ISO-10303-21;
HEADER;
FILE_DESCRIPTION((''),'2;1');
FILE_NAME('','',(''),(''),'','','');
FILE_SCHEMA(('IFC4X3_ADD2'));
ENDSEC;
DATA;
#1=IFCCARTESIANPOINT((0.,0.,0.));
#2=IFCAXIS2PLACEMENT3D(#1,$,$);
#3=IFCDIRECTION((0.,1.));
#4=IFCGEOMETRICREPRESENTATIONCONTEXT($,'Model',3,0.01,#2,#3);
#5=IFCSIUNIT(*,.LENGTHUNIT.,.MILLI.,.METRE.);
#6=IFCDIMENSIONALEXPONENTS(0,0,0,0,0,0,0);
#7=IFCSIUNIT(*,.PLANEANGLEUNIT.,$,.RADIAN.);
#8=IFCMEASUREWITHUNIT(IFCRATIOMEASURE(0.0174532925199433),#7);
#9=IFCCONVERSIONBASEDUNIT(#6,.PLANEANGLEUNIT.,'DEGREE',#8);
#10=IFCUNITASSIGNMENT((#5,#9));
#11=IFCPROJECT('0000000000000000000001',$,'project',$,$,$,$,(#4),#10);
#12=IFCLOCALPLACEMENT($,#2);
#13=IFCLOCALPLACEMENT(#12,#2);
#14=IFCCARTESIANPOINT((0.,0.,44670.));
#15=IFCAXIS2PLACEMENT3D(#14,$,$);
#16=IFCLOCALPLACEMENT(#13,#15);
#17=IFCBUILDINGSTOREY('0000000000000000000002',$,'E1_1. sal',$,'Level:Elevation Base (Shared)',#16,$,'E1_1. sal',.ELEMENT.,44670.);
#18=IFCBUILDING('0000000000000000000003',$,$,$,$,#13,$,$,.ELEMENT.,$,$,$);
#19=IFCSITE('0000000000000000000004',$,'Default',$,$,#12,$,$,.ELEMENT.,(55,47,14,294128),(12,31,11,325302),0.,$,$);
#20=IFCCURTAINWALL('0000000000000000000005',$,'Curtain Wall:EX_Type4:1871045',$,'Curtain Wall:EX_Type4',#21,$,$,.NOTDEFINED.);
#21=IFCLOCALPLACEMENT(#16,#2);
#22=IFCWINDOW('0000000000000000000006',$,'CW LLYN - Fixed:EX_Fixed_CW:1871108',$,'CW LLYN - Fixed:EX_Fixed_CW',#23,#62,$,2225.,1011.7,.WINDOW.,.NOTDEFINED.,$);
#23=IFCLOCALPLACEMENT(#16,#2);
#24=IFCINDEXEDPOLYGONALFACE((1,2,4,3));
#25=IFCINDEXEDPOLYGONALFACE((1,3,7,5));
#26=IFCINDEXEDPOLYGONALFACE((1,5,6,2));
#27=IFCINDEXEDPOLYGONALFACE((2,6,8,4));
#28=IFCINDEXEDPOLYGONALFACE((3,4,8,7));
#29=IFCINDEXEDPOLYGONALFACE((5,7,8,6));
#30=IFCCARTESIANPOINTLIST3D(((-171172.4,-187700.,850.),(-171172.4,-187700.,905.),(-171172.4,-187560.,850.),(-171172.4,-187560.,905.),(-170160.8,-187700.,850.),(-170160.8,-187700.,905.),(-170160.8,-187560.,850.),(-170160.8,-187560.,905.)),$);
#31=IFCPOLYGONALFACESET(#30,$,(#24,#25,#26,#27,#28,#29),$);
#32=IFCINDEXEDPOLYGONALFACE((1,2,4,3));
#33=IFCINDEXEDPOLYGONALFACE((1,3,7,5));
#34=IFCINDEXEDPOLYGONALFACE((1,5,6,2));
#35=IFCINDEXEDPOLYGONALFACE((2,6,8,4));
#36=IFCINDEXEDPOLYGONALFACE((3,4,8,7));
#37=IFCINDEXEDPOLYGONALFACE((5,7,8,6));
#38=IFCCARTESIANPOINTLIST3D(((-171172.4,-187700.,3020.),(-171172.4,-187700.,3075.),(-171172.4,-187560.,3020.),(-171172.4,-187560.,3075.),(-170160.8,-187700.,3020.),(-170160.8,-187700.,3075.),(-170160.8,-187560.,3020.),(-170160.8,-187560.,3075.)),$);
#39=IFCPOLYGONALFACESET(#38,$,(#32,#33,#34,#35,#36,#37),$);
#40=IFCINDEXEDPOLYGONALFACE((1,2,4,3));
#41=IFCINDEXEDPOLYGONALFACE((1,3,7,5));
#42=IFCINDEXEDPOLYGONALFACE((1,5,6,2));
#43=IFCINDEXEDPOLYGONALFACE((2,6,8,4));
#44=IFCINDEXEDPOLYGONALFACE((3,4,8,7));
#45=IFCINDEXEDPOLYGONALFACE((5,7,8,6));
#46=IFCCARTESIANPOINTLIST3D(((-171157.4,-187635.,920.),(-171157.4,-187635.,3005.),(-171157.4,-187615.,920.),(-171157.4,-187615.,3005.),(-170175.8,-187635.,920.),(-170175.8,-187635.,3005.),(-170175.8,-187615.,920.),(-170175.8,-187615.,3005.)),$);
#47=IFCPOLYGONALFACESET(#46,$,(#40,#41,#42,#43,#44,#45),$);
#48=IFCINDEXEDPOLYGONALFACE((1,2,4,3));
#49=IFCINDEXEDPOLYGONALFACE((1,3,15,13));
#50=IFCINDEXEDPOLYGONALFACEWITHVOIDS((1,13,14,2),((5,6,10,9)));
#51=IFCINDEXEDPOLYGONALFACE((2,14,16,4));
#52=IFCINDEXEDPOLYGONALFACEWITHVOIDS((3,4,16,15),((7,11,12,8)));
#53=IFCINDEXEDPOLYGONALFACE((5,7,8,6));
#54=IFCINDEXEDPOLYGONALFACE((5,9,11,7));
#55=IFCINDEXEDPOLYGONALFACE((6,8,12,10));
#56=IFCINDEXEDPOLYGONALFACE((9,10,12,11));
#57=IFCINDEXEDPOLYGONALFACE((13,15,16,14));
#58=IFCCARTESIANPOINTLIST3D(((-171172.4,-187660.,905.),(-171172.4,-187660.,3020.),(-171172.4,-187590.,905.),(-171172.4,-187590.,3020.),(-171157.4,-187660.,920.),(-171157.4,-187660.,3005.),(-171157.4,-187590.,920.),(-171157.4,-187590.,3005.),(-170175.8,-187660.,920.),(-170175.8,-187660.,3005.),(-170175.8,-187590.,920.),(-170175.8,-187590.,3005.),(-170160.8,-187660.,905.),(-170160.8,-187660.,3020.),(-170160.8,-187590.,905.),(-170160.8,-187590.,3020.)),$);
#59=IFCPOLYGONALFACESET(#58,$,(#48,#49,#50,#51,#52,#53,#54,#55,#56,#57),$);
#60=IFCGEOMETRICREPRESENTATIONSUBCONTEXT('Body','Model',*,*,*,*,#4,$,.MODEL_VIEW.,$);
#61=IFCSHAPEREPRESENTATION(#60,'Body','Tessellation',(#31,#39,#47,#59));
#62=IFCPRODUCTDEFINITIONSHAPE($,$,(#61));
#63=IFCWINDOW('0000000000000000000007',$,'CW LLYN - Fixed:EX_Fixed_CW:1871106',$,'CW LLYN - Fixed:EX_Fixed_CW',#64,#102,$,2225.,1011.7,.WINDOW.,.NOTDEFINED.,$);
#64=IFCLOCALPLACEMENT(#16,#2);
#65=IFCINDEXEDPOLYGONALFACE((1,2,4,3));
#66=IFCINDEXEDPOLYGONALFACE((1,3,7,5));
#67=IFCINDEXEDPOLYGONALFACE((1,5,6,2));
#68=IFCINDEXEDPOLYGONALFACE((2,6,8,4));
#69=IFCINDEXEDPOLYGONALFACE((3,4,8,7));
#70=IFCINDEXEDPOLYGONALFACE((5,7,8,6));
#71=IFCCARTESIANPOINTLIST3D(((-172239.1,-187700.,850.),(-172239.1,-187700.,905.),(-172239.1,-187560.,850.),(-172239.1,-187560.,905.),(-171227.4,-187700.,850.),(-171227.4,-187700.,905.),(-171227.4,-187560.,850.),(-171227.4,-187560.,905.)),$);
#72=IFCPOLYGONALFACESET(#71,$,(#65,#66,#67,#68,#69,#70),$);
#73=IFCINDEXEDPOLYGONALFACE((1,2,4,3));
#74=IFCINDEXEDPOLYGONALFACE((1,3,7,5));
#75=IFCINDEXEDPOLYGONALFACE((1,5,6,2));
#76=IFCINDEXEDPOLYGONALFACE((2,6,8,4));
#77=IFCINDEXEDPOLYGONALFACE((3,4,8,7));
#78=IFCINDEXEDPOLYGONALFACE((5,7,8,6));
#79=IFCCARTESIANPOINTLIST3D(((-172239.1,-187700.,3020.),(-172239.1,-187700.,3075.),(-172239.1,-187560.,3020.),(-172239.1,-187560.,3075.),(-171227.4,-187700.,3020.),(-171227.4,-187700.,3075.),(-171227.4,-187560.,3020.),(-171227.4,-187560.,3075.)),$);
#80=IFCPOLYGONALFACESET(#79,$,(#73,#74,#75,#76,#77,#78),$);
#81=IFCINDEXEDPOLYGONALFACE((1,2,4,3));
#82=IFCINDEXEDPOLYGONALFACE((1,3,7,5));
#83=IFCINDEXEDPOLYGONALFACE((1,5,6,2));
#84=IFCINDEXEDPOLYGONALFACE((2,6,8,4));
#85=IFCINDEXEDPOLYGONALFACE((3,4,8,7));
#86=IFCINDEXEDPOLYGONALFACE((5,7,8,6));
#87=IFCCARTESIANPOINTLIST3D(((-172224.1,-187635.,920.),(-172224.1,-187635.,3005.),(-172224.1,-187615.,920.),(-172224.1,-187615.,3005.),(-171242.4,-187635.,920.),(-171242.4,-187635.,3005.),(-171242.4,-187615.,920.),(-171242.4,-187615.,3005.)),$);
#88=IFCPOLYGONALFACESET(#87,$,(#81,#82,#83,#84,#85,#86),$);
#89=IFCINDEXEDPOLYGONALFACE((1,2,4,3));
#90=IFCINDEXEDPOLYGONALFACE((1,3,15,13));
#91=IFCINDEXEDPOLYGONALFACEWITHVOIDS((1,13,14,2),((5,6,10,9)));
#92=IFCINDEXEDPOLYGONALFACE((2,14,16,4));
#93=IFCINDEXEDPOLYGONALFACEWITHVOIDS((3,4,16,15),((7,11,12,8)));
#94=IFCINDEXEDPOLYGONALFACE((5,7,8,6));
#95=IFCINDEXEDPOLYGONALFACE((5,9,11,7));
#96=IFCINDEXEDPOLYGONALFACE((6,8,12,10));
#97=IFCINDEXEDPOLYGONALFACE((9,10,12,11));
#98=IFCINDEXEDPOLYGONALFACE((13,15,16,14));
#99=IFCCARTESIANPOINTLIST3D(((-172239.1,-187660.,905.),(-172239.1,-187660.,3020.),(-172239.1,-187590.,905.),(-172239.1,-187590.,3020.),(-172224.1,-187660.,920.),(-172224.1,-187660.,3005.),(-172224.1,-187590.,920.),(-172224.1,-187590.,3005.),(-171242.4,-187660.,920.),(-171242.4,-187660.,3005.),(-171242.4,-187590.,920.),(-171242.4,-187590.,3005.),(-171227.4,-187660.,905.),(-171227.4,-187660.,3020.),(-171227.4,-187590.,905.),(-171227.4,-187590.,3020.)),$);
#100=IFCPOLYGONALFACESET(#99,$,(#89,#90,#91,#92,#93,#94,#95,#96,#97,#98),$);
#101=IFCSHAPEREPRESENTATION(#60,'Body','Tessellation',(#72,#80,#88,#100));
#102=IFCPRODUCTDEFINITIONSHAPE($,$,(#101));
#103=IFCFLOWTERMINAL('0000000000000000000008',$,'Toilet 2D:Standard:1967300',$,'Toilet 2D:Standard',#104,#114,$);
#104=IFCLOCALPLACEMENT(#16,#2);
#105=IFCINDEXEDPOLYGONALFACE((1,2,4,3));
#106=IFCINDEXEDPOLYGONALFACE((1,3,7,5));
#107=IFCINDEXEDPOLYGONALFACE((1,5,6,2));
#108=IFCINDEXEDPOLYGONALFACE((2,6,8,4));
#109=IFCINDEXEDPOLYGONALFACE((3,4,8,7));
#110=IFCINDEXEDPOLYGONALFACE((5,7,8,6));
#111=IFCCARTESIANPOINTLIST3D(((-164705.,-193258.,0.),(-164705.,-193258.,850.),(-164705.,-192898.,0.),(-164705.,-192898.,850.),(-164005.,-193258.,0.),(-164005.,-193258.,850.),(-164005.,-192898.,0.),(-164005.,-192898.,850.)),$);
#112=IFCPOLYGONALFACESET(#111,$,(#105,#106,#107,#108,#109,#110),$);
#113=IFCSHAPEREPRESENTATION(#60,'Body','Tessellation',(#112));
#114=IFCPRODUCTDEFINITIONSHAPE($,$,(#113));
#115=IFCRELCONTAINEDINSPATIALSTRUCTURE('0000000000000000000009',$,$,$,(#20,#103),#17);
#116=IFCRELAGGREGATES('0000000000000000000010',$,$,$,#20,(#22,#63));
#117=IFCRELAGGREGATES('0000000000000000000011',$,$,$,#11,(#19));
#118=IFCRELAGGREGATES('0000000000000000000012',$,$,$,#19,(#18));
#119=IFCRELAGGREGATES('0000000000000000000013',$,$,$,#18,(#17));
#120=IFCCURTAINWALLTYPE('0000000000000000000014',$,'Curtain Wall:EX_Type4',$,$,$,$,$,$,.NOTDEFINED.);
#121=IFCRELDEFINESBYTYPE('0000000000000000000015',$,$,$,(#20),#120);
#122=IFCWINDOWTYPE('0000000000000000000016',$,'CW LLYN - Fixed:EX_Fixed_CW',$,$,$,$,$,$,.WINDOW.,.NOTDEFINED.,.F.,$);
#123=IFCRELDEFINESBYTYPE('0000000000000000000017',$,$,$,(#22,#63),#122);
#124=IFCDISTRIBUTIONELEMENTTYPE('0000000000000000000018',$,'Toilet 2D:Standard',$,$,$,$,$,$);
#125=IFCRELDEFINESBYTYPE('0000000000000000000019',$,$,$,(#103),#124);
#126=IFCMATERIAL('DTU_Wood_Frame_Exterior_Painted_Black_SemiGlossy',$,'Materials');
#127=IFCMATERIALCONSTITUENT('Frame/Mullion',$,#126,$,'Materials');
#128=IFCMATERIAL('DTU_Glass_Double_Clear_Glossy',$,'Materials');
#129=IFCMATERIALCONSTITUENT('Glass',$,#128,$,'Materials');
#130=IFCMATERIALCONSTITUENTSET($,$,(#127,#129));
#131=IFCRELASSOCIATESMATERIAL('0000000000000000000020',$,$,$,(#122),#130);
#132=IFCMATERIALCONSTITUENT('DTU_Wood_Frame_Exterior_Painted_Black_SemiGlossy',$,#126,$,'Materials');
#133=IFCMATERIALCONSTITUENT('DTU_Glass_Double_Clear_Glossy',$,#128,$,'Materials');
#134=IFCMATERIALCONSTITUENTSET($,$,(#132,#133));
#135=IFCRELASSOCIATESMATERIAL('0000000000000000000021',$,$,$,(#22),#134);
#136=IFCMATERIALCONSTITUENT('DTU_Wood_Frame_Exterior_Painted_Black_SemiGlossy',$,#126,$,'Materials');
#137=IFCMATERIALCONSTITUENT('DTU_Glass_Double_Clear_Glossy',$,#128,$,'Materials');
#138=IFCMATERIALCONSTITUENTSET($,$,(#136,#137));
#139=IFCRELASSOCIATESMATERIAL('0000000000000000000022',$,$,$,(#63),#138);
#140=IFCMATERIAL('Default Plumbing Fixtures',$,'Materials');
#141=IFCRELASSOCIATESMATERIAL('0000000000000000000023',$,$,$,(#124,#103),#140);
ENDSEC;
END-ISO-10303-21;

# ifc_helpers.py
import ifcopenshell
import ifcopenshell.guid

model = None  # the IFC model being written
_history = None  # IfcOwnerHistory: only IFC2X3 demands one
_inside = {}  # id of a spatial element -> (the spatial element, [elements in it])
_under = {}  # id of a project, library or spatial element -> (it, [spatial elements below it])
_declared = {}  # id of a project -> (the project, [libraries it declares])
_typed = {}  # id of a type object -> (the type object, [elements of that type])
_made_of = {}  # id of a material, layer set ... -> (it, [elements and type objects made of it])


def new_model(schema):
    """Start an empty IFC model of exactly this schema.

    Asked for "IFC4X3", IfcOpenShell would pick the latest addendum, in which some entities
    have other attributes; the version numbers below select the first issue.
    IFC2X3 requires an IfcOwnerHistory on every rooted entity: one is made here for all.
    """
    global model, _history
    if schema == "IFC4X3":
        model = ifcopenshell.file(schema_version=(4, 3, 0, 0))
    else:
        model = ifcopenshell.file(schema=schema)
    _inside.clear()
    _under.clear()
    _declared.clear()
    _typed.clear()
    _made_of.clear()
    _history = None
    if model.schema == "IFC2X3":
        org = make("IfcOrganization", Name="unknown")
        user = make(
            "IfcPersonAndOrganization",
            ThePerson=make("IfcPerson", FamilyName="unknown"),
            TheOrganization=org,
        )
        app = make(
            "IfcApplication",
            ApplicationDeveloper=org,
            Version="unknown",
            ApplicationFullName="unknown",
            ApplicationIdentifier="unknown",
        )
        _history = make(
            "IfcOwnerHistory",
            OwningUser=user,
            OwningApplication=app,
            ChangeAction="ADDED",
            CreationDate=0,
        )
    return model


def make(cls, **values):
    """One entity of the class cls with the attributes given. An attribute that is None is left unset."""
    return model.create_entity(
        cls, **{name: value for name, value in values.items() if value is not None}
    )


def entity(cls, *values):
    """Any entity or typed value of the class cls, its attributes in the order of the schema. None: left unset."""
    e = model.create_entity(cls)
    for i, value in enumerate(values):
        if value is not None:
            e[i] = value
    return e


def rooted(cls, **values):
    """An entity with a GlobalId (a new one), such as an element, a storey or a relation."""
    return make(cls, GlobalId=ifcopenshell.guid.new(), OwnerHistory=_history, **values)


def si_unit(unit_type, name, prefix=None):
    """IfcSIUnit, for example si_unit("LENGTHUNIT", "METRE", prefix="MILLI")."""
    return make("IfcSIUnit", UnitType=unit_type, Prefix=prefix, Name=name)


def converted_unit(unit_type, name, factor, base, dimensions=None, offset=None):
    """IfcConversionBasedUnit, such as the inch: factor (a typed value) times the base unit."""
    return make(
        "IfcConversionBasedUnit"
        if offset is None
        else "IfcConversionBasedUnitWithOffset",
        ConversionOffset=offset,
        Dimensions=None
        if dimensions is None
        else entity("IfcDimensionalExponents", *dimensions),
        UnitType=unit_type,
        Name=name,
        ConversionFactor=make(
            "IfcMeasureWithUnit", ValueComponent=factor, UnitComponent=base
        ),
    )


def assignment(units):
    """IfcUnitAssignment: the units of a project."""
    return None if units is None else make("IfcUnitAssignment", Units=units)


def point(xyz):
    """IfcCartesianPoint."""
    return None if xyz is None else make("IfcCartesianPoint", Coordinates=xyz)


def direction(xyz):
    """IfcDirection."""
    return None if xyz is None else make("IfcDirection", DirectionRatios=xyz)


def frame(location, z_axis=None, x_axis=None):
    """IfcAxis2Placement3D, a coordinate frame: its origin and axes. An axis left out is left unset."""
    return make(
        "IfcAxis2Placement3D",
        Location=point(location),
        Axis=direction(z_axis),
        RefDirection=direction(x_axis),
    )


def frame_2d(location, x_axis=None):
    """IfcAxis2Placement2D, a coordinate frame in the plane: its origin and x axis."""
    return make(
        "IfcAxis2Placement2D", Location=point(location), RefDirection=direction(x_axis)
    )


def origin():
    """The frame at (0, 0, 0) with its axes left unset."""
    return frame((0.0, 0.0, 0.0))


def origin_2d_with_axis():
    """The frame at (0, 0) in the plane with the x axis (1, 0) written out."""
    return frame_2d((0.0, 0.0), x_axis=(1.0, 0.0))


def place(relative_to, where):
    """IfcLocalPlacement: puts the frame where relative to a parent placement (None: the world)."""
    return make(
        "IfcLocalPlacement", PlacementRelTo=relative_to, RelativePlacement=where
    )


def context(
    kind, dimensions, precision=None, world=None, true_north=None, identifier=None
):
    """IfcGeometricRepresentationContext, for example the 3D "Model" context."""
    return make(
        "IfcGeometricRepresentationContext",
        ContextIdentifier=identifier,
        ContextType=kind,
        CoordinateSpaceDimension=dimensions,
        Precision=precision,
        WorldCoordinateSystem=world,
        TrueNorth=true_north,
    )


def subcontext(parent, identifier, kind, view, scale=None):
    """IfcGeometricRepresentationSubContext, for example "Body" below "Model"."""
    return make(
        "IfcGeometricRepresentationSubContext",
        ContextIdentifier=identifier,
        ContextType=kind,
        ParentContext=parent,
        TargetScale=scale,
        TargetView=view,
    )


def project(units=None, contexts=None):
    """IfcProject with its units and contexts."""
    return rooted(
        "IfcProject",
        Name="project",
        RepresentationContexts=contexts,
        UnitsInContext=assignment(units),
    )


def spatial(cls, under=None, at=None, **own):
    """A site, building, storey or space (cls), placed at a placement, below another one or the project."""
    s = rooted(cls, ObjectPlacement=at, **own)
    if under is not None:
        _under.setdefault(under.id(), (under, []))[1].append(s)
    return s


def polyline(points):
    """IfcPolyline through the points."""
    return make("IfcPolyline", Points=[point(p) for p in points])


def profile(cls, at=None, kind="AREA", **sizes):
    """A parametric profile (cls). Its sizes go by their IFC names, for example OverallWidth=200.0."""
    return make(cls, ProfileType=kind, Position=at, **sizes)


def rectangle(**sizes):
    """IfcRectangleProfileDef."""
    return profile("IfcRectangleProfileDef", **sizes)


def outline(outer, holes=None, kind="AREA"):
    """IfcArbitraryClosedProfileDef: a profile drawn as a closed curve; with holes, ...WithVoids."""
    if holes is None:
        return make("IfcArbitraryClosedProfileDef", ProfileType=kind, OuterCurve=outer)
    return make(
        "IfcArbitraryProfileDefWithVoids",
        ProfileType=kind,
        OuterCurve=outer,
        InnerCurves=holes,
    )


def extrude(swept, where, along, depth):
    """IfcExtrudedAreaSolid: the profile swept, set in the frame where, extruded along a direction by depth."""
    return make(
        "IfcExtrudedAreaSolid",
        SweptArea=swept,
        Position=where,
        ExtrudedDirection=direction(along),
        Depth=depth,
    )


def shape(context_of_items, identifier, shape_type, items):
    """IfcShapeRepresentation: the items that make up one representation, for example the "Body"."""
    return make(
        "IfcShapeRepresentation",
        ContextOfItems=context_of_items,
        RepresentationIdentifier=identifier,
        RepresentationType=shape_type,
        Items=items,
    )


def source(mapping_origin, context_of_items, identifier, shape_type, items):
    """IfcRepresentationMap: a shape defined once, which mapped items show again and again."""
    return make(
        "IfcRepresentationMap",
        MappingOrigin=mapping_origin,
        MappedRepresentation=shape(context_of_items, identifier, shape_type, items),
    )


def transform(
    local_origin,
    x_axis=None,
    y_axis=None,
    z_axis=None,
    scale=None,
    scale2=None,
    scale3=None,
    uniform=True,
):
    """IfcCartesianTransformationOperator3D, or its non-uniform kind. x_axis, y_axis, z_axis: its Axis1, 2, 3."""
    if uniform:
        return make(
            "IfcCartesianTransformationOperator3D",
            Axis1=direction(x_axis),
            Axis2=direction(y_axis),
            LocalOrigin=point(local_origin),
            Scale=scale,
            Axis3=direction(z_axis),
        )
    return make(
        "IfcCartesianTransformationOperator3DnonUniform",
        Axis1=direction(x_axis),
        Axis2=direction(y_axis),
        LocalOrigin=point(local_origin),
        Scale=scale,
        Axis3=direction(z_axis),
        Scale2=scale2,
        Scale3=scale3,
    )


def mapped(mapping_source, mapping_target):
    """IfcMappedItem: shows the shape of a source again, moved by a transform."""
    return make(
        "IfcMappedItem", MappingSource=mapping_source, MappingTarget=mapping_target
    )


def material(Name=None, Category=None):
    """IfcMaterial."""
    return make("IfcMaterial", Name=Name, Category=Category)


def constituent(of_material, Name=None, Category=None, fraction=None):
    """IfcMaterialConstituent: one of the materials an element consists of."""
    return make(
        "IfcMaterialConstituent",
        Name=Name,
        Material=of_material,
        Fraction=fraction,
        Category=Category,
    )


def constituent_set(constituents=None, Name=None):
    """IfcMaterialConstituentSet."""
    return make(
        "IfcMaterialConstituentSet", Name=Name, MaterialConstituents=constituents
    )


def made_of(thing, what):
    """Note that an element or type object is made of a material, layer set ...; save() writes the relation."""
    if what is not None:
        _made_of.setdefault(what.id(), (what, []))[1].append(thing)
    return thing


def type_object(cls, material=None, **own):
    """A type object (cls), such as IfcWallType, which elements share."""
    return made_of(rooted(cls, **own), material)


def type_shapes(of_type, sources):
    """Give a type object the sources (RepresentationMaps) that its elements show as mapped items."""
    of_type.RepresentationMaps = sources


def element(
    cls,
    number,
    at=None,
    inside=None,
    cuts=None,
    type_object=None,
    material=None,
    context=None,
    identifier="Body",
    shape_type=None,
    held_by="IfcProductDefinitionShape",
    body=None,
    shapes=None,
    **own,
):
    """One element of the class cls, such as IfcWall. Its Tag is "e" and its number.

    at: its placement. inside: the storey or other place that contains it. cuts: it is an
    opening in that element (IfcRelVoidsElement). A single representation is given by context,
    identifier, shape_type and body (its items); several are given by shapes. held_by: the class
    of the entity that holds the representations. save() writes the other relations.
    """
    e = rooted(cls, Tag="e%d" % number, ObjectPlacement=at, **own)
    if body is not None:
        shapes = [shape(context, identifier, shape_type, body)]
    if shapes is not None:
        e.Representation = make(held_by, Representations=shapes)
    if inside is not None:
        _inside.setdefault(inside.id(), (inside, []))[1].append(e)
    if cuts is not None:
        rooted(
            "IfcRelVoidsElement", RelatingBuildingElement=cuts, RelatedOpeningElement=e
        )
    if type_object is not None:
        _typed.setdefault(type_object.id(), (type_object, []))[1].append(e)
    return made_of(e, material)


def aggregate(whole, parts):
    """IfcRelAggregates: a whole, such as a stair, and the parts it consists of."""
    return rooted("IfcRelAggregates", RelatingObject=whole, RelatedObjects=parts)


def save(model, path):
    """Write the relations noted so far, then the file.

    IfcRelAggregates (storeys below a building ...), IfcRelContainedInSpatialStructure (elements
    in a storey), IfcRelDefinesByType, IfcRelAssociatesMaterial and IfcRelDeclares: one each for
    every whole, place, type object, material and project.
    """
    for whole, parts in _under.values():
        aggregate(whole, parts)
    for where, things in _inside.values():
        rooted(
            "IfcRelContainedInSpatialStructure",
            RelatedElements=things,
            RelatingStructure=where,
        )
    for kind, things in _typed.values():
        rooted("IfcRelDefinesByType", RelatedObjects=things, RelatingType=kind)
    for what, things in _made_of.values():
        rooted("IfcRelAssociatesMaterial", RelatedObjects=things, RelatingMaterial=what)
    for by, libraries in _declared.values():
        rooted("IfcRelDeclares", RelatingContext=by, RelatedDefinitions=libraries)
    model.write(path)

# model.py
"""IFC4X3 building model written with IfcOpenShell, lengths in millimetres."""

from ifc_helpers import new_model, entity, si_unit, converted_unit, direction, frame, frame_2d, origin, origin_2d_with_axis, place, context, subcontext, project, spatial, polyline, rectangle, outline, extrude, source, transform, mapped, material, constituent, constituent_set, type_object, type_shapes, element, aggregate, save


model = new_model("IFC4X3")

# Units and contexts
model_context = context("Model", 3, precision=0.01, world=origin(), true_north=direction((0.0, 1.0)))
body_context = subcontext(model_context, "Body", "Model", "MODEL_VIEW")
ifc_project = project(units=[si_unit("LENGTHUNIT", "METRE", prefix="MILLI"), converted_unit("PLANEANGLEUNIT", "DEGREE", entity("IfcRatioMeasure", 0.0174532925199433), si_unit("PLANEANGLEUNIT", "RADIAN"), dimensions=[0, 0, 0, 0, 0, 0, 0])], contexts=[model_context])

# Site, building, storey
site_placement = place(None, origin())
site = spatial("IfcSite", under=ifc_project, at=site_placement, Name="Default", CompositionType="ELEMENT", RefLatitude=(55, 47, 14, 294128), RefLongitude=(12, 31, 11, 325302), RefElevation=0.0)
building_placement = place(site_placement, origin())
building = spatial("IfcBuilding", under=site, at=building_placement, CompositionType="ELEMENT")
storey_placement = place(building_placement, frame((0.0, 0.0, 44670.0)))
storey = spatial("IfcBuildingStorey", under=building, at=storey_placement, Name="E1_1. sal", ObjectType="Level:Elevation Base (Shared)", LongName="E1_1. sal", CompositionType="ELEMENT", Elevation=44670.0)

# Curtain wall
curtain_wall_type = type_object("IfcCurtainWallType", Name="Curtain Wall:EX_Type4", PredefinedType="NOTDEFINED")
curtain_wall_placement = place(storey_placement, frame((0.0, 0.0, -44670.0)))
curtain_wall = element("IfcCurtainWall", 1, at=curtain_wall_placement, inside=storey, type_object=curtain_wall_type, Name="Curtain Wall:EX_Type4:1871045", ObjectType="Curtain Wall:EX_Type4", PredefinedType="NOTDEFINED")

# Windows
ifc_material_1 = material(Name="DTU_Wood_Frame_Exterior_Painted_Black_SemiGlossy", Category="Materials")
ifc_material_2 = material(Name="DTU_Glass_Double_Clear_Glossy", Category="Materials")
ifc_constituent_1 = constituent(ifc_material_1, Name="Frame/Mullion", Category="Materials")
ifc_constituent_2 = constituent(ifc_material_2, Name="Glass", Category="Materials")
ifc_constituent_set_1 = constituent_set(constituents=[ifc_constituent_1, ifc_constituent_2])
window_type_1 = type_object("IfcWindowType", Name="CW LLYN - Fixed:EX_Fixed_CW", ParameterTakesPrecedence=False, PartitioningType="NOTDEFINED", PredefinedType="WINDOW", material=ifc_constituent_set_1)
shared_shape_1 = source(origin(), body_context, "Body", "SweptSolid", [
    extrude(rectangle(XDim=140.0, YDim=1011.7, at=origin_2d_with_axis()), frame((0.0, -130.0, 0.0), z_axis=(0.0, 0.0, 1.0), x_axis=(0.0, -1.0, 0.0)), (0.0, 0.0, 1.0), 55.0),
    extrude(rectangle(XDim=140.0, YDim=1011.7, at=frame_2d((0.0, 0.0), x_axis=(1.0, 0.0))), frame((0.0, -130.0, 2170.0), z_axis=(0.0, 0.0, 1.0), x_axis=(0.0, -1.0, 0.0)), (0.0, 0.0, 1.0), 55.0),
    extrude(rectangle(XDim=981.7, YDim=20.0, at=frame_2d((0.0, 0.0), x_axis=(1.0, 0.0))), frame((0.0, -125.0, 70.0), z_axis=(0.0, 0.0, 1.0), x_axis=(-1.0, 0.0, 0.0)), (0.0, 0.0, 1.0), 2085.0),
    extrude(outline(polyline([(-1057.5, -505.8), (1057.5, -505.8), (1057.5, 505.8), (-1057.5, 505.8), (-1057.5, -505.8)]), holes=[polyline([(-1042.5, 490.8), (1042.5, 490.8), (1042.5, -490.8), (-1042.5, -490.8), (-1042.5, 490.8)])]), frame((0.0, -90.0, 1112.5), z_axis=(0.0, -1.0, 0.0), x_axis=(0.0, 0.0, 1.0)), (0.0, 0.0, 1.0), 70.0),
])
type_shapes(window_type_1, [shared_shape_1])
ifc_constituent_3 = constituent(ifc_material_1, Name="DTU_Wood_Frame_Exterior_Painted_Black_SemiGlossy", Category="Materials")
ifc_constituent_4 = constituent(ifc_material_2, Name="DTU_Glass_Double_Clear_Glossy", Category="Materials")
ifc_constituent_set_2 = constituent_set(constituents=[ifc_constituent_3, ifc_constituent_4])
window_1_placement = place(curtain_wall_placement, frame((-170666.6, -187500.0, 45520.0)))
window_1 = element("IfcWindow", 2, at=window_1_placement, type_object=window_type_1, material=ifc_constituent_set_2, Name="CW LLYN - Fixed:EX_Fixed_CW:1871108", ObjectType="CW LLYN - Fixed:EX_Fixed_CW", OverallHeight=2225.0, OverallWidth=1011.7, PartitioningType="NOTDEFINED", PredefinedType="WINDOW", context=body_context, shape_type="MappedRepresentation", body=[
    mapped(shared_shape_1, transform((0.0, 0.0, 0.0), scale=1.0)),
])
ifc_constituent_5 = constituent(ifc_material_1, Name="DTU_Wood_Frame_Exterior_Painted_Black_SemiGlossy", Category="Materials")
ifc_constituent_6 = constituent(ifc_material_2, Name="DTU_Glass_Double_Clear_Glossy", Category="Materials")
ifc_constituent_set_3 = constituent_set(constituents=[ifc_constituent_5, ifc_constituent_6])
window_2_placement = place(curtain_wall_placement, frame((-171733.3, -187500.0, 45520.0)))
window_2 = element("IfcWindow", 3, at=window_2_placement, type_object=window_type_1, material=ifc_constituent_set_3, Name="CW LLYN - Fixed:EX_Fixed_CW:1871106", ObjectType="CW LLYN - Fixed:EX_Fixed_CW", OverallHeight=2225.0, OverallWidth=1011.7, PartitioningType="NOTDEFINED", PredefinedType="WINDOW", context=body_context, shape_type="MappedRepresentation", body=[
    mapped(shared_shape_1, transform((0.0, 0.0, 0.0), scale=1.0)),
])

aggregate(curtain_wall, [window_1, window_2])

# Flow terminal
ifc_material_3 = material(Name="Default Plumbing Fixtures", Category="Materials")
distribution_element_type = type_object("IfcDistributionElementType", Name="Toilet 2D:Standard", material=ifc_material_3)
shared_shape_2 = source(origin(), body_context, "Body", "SweptSolid", [
    extrude(rectangle(XDim=360.0, YDim=700.0, at=frame_2d((0.0, 0.0), x_axis=(1.0, 0.0))), frame((180.0, 350.0, 0.0), z_axis=(0.0, 0.0, 1.0), x_axis=(-1.0, 0.0, 0.0)), (0.0, 0.0, 1.0), 850.0),
])
type_shapes(distribution_element_type, [shared_shape_2])
flow_terminal_placement = place(storey_placement, frame((-164705.0, -192898.0, 0.0), z_axis=(0.0, 0.0, 1.0), x_axis=(0.0, -1.0, 0.0)))
element("IfcFlowTerminal", 4, at=flow_terminal_placement, inside=storey, type_object=distribution_element_type, material=ifc_material_3, Name="Toilet 2D:Standard:1967300", ObjectType="Toilet 2D:Standard", context=body_context, shape_type="MappedRepresentation", body=[
    mapped(shared_shape_2, transform((0.0, 0.0, 0.0), scale=1.0)),
])

save(model, "model.ifc")
